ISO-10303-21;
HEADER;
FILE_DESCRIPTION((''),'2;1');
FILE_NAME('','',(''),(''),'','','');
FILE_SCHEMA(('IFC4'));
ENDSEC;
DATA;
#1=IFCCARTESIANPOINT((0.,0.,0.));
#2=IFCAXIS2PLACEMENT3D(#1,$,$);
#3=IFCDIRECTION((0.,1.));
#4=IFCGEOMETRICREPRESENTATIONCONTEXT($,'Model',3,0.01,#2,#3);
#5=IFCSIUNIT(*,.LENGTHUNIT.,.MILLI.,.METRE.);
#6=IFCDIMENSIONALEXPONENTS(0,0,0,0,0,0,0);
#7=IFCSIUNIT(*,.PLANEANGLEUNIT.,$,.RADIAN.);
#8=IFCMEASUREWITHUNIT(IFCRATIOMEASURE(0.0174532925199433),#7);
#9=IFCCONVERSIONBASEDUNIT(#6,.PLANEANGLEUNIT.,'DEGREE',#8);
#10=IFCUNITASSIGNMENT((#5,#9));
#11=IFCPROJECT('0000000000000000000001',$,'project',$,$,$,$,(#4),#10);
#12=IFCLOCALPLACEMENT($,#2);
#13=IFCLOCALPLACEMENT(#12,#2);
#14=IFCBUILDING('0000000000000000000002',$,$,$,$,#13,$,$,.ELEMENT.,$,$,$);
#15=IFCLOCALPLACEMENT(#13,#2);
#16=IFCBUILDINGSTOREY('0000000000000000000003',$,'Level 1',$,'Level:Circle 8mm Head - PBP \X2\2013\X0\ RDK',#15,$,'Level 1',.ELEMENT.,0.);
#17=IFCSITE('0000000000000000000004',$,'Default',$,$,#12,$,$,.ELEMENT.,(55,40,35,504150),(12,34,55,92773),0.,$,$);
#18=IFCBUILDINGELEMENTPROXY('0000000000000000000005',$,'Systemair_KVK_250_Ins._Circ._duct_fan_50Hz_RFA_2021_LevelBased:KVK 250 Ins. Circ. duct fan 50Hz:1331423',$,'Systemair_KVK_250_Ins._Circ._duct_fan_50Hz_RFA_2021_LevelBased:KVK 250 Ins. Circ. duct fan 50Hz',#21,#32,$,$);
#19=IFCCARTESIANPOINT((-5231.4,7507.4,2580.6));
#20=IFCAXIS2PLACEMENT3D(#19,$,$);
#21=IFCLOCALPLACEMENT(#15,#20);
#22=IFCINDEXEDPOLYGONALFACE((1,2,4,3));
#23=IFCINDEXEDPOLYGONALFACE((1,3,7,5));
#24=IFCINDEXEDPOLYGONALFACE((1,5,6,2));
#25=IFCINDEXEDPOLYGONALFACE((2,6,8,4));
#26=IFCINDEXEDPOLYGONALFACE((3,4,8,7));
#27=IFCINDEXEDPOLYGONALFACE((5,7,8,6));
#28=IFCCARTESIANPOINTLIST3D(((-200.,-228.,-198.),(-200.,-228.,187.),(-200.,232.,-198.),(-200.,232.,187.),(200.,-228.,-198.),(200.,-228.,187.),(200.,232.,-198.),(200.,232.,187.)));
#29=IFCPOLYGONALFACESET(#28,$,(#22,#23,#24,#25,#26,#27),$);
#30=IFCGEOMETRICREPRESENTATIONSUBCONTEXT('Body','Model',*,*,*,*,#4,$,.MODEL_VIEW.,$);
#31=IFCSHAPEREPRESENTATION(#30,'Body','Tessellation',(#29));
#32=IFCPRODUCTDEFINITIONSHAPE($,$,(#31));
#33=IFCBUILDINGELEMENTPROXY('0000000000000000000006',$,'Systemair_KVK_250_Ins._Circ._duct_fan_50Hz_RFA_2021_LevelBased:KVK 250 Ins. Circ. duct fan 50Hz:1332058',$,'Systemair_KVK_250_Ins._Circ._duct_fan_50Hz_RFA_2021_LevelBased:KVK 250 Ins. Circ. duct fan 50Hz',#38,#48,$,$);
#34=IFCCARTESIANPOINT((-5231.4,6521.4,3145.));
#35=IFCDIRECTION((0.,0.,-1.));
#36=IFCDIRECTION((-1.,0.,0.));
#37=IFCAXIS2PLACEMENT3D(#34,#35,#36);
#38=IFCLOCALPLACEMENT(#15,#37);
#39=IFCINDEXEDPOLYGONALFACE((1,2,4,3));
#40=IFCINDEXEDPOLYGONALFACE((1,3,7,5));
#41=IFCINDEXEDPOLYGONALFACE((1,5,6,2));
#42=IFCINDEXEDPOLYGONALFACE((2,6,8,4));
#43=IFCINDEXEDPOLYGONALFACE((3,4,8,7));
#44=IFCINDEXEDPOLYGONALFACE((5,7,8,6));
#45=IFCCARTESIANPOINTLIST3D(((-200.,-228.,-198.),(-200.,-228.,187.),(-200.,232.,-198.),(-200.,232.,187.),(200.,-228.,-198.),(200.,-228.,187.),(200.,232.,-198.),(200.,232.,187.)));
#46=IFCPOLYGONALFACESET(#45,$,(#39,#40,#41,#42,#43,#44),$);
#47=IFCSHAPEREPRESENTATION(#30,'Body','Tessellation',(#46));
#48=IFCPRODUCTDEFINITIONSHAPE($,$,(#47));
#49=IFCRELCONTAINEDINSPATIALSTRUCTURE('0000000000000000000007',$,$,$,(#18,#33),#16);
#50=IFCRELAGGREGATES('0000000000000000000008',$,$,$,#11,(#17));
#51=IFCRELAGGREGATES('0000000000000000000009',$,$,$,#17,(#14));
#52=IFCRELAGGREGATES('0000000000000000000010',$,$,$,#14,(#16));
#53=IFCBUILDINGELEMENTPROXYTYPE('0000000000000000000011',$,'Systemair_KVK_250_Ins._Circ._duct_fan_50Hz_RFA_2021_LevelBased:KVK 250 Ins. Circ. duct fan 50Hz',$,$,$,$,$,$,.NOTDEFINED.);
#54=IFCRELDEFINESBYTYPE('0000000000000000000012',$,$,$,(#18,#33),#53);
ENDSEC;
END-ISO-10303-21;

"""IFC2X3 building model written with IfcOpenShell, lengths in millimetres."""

from ifc_helpers import new_model, entity, si_unit, converted_unit, direction, frame, origin, origin_2d_with_axis, place, context, subcontext, project, spatial, rectangle, extrude, source, transform, mapped, type_object, type_shapes, element, save


model = new_model("IFC2X3")

# Units and contexts
model_context = context("Model", 3, precision=0.01, world=origin(), true_north=direction((0.0, 1.0)))
body_context = subcontext(model_context, "Body", "Model", "MODEL_VIEW")
ifc_project = project(units=[si_unit("LENGTHUNIT", "METRE", prefix="MILLI"), converted_unit("PLANEANGLEUNIT", "DEGREE", entity("IfcRatioMeasure", 0.0174532925199433), si_unit("PLANEANGLEUNIT", "RADIAN"), dimensions=[0, 0, 0, 0, 0, 0, 0])], contexts=[model_context])

# Site, building, storey
site_placement = place(None, origin())
site = spatial("IfcSite", under=ifc_project, at=site_placement, Name="Default", CompositionType="ELEMENT", RefLatitude=(55, 40, 35, 504150), RefLongitude=(12, 34, 55, 92773), RefElevation=0.0)
building_placement = place(site_placement, origin())
building = spatial("IfcBuilding", under=site, at=building_placement, CompositionType="ELEMENT")
storey_placement = place(building_placement, origin())
storey = spatial("IfcBuildingStorey", under=building, at=storey_placement, Name="Level 1", ObjectType="Level:Circle 8mm Head - PBP – RDK", LongName="Level 1", CompositionType="ELEMENT", Elevation=0.0)

# Building element proxies
building_element_proxy_type_1 = type_object("IfcBuildingElementProxyType", Name="Systemair_KVK_250_Ins._Circ._duct_fan_50Hz_RFA_2021_LevelBased:KVK 250 Ins. Circ. duct fan 50Hz", PredefinedType="NOTDEFINED")
shared_shape_1 = source(origin(), body_context, "Body", "SweptSolid", [
    extrude(rectangle(XDim=400.0, YDim=460.0, at=origin_2d_with_axis()), frame((0.0, 2.0, -198.0)), (0.0, 0.0, 1.0), 385.0),
])
type_shapes(building_element_proxy_type_1, [shared_shape_1])
proxy_1_placement = place(storey_placement, frame((-5231.4, 7507.4, 2580.6)))
element("IfcBuildingElementProxy", 1, at=proxy_1_placement, inside=storey, type_object=building_element_proxy_type_1, Name="Systemair_KVK_250_Ins._Circ._duct_fan_50Hz_RFA_2021_LevelBased:KVK 250 Ins. Circ. duct fan 50Hz:1331423", ObjectType="Systemair_KVK_250_Ins._Circ._duct_fan_50Hz_RFA_2021_LevelBased:KVK 250 Ins. Circ. duct fan 50Hz", context=body_context, shape_type="MappedRepresentation", body=[
    mapped(shared_shape_1, transform((0.0, 0.0, 0.0), scale=1.0)),
])
proxy_2_placement = place(storey_placement, frame((-5231.4, 6521.4, 3145.0), z_axis=(0.0, 0.0, -1.0), x_axis=(-1.0, 0.0, 0.0)))
element("IfcBuildingElementProxy", 2, at=proxy_2_placement, inside=storey, type_object=building_element_proxy_type_1, Name="Systemair_KVK_250_Ins._Circ._duct_fan_50Hz_RFA_2021_LevelBased:KVK 250 Ins. Circ. duct fan 50Hz:1332058", ObjectType="Systemair_KVK_250_Ins._Circ._duct_fan_50Hz_RFA_2021_LevelBased:KVK 250 Ins. Circ. duct fan 50Hz", context=body_context, shape_type="MappedRepresentation", body=[
    mapped(shared_shape_1, transform((0.0, 0.0, 0.0), scale=1.0)),
])

save(model, "model.ifc")
